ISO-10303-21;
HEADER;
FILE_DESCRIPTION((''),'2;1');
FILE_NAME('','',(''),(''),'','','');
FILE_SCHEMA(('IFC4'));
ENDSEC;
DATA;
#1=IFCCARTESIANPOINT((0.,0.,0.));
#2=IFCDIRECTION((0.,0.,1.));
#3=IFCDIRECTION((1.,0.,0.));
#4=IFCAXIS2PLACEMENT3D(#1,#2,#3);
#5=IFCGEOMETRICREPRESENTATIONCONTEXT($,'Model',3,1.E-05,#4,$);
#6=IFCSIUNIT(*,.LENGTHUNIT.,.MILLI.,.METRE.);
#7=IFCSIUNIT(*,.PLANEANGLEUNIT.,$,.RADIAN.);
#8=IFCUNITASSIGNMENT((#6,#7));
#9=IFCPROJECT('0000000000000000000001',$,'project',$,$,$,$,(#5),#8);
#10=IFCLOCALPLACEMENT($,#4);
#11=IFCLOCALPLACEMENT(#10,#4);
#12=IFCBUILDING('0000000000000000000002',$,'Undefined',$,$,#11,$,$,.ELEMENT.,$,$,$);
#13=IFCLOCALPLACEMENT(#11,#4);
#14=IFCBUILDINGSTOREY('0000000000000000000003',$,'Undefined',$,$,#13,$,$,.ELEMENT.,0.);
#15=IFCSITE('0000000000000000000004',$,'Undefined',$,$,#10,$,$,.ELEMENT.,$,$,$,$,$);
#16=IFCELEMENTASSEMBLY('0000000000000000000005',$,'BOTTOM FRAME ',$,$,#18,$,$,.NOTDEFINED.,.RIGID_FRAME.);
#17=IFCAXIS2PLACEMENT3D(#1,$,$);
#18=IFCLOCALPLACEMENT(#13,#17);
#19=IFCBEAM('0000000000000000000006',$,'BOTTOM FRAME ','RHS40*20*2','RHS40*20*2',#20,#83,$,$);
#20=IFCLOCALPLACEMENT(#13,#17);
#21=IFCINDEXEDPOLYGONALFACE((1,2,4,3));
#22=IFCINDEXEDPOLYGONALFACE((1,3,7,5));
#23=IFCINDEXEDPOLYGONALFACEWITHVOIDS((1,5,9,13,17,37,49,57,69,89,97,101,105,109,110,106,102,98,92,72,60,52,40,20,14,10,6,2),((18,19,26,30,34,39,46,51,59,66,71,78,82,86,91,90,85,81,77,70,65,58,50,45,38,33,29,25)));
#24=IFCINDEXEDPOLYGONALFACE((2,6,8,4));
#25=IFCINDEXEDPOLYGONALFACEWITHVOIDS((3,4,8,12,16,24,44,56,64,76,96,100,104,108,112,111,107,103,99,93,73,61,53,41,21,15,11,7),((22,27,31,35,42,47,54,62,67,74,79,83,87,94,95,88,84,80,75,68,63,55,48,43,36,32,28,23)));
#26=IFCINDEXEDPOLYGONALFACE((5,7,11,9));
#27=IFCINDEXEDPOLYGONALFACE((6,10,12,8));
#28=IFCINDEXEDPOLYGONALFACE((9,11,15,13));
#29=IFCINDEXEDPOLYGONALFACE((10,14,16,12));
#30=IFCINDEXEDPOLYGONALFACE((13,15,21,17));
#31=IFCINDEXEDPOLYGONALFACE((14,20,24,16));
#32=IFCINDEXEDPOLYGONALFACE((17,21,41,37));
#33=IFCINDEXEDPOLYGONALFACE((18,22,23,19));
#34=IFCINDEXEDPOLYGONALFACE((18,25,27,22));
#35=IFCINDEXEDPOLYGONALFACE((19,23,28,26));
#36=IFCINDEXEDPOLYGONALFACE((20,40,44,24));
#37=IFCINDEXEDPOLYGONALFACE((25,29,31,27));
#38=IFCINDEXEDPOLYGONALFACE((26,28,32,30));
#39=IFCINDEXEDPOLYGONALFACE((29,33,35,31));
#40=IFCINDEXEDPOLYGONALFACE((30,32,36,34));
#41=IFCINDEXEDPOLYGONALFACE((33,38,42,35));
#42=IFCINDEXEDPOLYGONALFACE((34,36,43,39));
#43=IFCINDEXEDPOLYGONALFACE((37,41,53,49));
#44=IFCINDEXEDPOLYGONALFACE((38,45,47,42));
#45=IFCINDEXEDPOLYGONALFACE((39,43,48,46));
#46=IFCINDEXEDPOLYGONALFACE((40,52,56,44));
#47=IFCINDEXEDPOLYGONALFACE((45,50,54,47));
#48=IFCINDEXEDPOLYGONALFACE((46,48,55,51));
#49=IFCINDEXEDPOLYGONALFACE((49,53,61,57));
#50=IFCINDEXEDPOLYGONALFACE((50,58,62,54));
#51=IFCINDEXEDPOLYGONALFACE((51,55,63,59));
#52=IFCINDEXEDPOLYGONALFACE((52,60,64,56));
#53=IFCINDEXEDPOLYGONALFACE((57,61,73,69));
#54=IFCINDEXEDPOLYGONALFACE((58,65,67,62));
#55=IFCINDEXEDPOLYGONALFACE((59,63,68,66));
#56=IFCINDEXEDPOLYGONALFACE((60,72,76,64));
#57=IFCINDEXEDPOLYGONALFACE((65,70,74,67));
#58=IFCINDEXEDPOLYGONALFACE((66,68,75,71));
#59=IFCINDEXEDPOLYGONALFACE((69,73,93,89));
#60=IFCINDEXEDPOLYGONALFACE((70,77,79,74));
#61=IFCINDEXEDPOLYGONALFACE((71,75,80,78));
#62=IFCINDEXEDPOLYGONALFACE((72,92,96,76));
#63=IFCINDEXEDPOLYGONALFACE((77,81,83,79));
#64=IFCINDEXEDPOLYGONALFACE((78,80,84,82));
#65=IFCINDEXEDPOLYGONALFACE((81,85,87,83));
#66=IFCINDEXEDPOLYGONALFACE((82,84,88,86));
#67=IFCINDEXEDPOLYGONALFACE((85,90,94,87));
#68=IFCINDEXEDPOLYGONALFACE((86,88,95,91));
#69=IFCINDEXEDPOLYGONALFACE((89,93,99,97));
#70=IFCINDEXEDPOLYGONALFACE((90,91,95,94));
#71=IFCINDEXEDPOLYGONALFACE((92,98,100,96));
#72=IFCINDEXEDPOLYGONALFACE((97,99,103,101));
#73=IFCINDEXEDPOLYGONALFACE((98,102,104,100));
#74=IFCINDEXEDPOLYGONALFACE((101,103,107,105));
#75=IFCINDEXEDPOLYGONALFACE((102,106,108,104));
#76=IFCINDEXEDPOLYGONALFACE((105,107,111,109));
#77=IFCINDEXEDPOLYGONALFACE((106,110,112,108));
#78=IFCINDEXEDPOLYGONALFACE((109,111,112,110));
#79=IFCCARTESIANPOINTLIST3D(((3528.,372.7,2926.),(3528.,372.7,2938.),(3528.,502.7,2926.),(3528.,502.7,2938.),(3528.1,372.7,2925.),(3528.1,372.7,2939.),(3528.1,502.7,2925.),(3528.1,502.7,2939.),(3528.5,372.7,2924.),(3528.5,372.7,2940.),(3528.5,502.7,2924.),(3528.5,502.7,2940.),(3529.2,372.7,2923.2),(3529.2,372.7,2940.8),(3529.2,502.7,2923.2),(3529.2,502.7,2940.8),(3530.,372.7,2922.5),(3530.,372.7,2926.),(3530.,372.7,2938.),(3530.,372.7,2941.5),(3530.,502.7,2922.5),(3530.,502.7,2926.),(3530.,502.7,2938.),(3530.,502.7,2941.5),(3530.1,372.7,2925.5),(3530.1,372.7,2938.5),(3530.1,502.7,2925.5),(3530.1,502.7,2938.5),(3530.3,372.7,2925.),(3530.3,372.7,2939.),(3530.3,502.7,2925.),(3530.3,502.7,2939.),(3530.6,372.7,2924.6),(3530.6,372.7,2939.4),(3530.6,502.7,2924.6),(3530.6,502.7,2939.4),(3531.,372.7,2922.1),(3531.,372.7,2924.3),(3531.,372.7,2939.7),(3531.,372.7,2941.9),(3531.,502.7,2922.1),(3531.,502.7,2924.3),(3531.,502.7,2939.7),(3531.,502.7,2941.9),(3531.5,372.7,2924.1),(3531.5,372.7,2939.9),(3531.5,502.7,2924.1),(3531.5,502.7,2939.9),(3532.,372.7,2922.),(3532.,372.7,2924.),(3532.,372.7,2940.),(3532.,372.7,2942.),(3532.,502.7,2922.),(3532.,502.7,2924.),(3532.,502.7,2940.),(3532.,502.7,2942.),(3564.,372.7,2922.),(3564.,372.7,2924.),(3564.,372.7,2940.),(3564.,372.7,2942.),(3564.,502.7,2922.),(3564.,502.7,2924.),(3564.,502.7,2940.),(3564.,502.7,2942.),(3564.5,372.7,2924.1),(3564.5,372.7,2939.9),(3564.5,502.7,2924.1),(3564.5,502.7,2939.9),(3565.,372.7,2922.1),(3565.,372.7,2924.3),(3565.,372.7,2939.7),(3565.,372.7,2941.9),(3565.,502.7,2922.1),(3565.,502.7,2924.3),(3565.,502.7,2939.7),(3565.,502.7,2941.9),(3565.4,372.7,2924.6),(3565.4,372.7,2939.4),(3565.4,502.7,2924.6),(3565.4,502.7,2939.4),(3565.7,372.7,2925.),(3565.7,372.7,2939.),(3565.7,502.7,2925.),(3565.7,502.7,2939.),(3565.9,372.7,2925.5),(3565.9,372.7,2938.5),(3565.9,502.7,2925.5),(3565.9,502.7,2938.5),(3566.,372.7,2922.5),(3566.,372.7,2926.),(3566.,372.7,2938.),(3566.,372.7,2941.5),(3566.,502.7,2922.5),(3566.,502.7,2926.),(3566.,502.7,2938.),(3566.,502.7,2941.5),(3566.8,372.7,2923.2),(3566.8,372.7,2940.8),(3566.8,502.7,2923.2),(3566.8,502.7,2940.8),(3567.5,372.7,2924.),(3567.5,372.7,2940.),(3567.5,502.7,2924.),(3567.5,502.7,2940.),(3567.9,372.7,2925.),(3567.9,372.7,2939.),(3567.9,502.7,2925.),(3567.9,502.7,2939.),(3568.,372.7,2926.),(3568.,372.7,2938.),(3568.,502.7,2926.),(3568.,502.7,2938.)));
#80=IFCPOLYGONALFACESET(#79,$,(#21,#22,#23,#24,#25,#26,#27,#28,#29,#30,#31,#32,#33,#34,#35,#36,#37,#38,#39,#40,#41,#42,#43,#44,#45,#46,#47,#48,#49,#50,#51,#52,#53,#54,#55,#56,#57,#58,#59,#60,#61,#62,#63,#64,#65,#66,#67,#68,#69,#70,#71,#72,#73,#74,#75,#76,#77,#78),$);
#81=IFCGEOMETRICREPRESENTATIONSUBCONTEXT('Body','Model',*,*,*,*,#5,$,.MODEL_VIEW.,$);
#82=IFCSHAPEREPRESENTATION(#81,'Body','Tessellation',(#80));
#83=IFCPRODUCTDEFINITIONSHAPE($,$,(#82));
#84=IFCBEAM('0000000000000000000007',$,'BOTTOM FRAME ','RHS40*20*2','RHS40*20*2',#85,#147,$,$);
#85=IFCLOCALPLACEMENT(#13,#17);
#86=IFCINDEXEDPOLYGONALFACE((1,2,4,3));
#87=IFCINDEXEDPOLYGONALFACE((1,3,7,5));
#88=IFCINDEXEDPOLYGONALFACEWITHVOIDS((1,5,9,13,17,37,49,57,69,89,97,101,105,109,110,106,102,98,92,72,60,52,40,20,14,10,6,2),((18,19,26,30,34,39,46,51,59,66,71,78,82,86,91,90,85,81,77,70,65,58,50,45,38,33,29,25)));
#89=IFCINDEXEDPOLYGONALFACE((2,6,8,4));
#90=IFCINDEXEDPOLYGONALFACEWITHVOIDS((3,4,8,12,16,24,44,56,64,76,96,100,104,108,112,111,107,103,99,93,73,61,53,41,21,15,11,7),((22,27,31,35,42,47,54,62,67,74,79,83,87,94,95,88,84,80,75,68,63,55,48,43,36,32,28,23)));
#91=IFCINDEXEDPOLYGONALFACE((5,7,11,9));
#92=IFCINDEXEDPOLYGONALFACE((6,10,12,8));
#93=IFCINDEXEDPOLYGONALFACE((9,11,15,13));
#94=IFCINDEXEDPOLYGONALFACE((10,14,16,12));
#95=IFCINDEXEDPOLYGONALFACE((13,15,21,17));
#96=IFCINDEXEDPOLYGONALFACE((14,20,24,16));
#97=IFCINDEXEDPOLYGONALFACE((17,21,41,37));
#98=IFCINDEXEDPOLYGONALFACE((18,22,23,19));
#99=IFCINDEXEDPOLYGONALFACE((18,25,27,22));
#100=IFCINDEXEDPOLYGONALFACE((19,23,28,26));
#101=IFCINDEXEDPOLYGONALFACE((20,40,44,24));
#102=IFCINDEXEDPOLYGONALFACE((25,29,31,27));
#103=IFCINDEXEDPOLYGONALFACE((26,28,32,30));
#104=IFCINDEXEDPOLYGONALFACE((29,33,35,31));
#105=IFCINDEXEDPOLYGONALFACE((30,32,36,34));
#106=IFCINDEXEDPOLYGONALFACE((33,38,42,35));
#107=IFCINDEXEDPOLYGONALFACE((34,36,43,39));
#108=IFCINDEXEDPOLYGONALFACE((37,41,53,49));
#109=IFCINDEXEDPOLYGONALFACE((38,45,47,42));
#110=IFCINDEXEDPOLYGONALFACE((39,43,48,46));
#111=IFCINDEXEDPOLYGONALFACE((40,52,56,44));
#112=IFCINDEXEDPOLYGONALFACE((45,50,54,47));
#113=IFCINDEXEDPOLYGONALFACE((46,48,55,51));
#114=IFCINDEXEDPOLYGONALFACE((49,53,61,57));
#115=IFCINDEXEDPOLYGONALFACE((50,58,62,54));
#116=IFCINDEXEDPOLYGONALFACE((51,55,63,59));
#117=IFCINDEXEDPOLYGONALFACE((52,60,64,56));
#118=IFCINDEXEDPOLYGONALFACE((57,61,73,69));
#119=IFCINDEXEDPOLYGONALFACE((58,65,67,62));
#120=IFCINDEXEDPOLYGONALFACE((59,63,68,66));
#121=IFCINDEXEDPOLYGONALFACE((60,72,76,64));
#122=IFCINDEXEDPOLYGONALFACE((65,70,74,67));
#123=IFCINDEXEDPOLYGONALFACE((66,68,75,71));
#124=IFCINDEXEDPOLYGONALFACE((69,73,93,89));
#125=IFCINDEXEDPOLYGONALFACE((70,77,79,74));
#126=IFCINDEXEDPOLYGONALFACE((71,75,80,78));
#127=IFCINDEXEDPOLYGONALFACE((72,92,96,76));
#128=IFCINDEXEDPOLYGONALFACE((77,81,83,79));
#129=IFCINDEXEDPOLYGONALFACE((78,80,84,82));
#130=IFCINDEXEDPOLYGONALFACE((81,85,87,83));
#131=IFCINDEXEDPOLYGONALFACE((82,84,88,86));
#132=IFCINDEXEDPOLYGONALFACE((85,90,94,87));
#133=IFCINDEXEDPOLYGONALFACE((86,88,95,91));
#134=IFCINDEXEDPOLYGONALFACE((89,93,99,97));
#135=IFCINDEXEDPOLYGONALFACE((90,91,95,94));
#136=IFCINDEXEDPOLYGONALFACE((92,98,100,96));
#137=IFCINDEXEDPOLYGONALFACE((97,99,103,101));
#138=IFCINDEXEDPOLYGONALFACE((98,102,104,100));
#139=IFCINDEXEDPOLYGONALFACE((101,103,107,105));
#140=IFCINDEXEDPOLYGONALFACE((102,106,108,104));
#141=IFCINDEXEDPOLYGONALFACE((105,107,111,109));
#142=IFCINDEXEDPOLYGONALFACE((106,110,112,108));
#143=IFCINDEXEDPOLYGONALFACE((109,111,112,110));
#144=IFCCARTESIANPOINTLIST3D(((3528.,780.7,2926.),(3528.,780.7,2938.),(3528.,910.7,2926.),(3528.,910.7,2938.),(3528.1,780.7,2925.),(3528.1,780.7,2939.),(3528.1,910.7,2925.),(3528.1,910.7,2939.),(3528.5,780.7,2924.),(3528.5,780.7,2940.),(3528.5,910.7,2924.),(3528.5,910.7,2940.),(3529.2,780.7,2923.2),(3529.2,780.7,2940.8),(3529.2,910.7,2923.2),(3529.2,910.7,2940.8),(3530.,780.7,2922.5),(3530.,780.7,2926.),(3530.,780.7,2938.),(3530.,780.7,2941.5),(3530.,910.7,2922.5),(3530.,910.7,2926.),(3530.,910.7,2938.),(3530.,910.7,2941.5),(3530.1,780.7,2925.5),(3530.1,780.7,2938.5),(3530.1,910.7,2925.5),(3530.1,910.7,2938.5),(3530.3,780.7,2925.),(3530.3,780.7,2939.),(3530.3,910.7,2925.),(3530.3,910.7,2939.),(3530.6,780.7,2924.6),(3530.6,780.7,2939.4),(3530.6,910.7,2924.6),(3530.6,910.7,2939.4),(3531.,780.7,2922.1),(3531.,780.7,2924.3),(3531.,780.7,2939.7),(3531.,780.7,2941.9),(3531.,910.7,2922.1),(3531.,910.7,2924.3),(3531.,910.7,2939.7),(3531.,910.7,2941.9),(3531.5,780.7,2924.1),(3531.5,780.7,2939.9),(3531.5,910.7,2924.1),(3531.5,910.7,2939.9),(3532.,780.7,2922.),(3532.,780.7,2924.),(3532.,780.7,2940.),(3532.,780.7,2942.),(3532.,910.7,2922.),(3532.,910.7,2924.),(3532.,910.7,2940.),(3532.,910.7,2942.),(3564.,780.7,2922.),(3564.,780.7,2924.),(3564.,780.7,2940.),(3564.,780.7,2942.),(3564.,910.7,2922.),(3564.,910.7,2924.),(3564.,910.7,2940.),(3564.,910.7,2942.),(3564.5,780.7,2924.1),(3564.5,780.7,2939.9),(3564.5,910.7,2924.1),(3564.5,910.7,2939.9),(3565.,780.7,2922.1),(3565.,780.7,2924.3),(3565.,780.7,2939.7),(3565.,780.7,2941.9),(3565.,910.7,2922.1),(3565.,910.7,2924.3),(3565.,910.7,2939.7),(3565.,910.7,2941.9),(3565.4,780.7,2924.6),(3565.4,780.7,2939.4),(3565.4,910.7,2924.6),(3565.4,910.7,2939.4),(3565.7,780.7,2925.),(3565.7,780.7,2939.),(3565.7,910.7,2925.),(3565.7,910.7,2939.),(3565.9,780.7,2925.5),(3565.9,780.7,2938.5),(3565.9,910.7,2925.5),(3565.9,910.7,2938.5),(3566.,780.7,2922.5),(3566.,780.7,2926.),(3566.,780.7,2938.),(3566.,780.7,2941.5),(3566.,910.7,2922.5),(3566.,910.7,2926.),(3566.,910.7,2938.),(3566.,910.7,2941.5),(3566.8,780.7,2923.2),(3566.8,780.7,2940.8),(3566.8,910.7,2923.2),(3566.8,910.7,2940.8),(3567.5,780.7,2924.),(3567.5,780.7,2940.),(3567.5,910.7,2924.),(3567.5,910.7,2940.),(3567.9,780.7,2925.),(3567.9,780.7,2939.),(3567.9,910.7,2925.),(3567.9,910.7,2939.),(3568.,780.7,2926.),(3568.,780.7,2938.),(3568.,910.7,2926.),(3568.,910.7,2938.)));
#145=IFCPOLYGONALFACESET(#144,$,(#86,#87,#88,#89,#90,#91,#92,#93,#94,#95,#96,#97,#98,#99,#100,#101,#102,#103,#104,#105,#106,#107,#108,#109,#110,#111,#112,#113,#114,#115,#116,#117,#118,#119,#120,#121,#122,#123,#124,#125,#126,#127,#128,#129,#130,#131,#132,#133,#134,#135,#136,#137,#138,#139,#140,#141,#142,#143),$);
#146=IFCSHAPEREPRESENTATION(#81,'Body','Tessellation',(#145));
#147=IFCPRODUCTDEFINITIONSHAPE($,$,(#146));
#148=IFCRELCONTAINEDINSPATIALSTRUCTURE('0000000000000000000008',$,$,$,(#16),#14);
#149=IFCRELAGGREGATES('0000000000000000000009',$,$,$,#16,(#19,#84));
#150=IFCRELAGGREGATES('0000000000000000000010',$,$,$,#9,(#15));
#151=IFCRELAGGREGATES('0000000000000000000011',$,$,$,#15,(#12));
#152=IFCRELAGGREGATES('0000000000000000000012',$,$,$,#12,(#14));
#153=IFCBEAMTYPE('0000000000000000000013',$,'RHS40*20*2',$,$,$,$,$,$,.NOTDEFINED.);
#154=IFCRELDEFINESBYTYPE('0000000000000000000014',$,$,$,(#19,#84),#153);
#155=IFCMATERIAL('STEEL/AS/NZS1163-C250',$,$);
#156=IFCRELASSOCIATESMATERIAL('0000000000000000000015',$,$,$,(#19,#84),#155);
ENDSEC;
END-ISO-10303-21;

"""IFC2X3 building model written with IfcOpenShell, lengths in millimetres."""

from ifc_helpers import new_model, si_unit, frame, origin_with_axes, origin_2d_with_axis, place, context, subcontext, project, spatial, hollow_rectangle, extrude, material, type_object, element, aggregate, save


model = new_model("IFC2X3")

# Units and contexts
model_context = context("Model", 3, precision=1e-05, world=origin_with_axes())
body_context = subcontext(model_context, "Body", "Model", "MODEL_VIEW")
ifc_project = project(units=[si_unit("LENGTHUNIT", "METRE", prefix="MILLI"), si_unit("PLANEANGLEUNIT", "RADIAN")], contexts=[model_context])

# Site, building, storey
site_placement = place(None, origin_with_axes())
site = spatial("IfcSite", under=ifc_project, at=site_placement, Name="Undefined", CompositionType="ELEMENT")
building_placement = place(site_placement, origin_with_axes())
building = spatial("IfcBuilding", under=site, at=building_placement, Name="Undefined", CompositionType="ELEMENT")
storey_placement = place(building_placement, origin_with_axes())
storey = spatial("IfcBuildingStorey", under=building, at=storey_placement, Name="Undefined", CompositionType="ELEMENT", Elevation=0.0)

# Element assembly, beams
assembly_1_placement = place(storey_placement, origin_with_axes())
assembly_1 = element("IfcElementAssembly", 1, at=assembly_1_placement, inside=storey, Name="BOTTOM FRAME ", AssemblyPlace="NOTDEFINED", PredefinedType="RIGID_FRAME")
ifc_material_1 = material(Name="STEEL/AS/NZS1163-C250")
beam_type_1 = type_object("IfcBeamType", Name="RHS40*20*2", PredefinedType="NOTDEFINED")
beam_1_placement = place(assembly_1_placement, frame((3548.0, 502.7, 2932.0), z_axis=(1.0, 0.0, 0.0), x_axis=(0.0, -1.0, 0.0)))
beam_1 = element("IfcBeam", 2, at=beam_1_placement, type_object=beam_type_1, material=ifc_material_1, Name="BOTTOM FRAME ", Description="RHS40*20*2", ObjectType="RHS40*20*2", context=body_context, shape_type="SweptSolid", body=[
    extrude(hollow_rectangle(XDim=20.0, YDim=40.0, WallThickness=2.0, InnerFilletRadius=2.0, OuterFilletRadius=4.0, at=origin_2d_with_axis()), frame((130.0, 0.0, 0.0), z_axis=(-1.0, 0.0, 0.0), x_axis=(0.0, -1.0, 0.0)), (0.0, 0.0, 1.0), 130.0),
])
beam_2_placement = place(assembly_1_placement, frame((3548.0, 910.7, 2932.0), z_axis=(1.0, 0.0, 0.0), x_axis=(0.0, -1.0, 0.0)))
beam_2 = element("IfcBeam", 3, at=beam_2_placement, type_object=beam_type_1, material=ifc_material_1, Name="BOTTOM FRAME ", Description="RHS40*20*2", ObjectType="RHS40*20*2", context=body_context, shape_type="SweptSolid", body=[
    extrude(hollow_rectangle(XDim=20.0, YDim=40.0, WallThickness=2.0, InnerFilletRadius=2.0, OuterFilletRadius=4.0, at=origin_2d_with_axis()), frame((130.0, 0.0, 0.0), z_axis=(-1.0, 0.0, 0.0), x_axis=(0.0, -1.0, 0.0)), (0.0, 0.0, 1.0), 130.0),
])

aggregate(assembly_1, [beam_1, beam_2])

save(model, "model.ifc")
